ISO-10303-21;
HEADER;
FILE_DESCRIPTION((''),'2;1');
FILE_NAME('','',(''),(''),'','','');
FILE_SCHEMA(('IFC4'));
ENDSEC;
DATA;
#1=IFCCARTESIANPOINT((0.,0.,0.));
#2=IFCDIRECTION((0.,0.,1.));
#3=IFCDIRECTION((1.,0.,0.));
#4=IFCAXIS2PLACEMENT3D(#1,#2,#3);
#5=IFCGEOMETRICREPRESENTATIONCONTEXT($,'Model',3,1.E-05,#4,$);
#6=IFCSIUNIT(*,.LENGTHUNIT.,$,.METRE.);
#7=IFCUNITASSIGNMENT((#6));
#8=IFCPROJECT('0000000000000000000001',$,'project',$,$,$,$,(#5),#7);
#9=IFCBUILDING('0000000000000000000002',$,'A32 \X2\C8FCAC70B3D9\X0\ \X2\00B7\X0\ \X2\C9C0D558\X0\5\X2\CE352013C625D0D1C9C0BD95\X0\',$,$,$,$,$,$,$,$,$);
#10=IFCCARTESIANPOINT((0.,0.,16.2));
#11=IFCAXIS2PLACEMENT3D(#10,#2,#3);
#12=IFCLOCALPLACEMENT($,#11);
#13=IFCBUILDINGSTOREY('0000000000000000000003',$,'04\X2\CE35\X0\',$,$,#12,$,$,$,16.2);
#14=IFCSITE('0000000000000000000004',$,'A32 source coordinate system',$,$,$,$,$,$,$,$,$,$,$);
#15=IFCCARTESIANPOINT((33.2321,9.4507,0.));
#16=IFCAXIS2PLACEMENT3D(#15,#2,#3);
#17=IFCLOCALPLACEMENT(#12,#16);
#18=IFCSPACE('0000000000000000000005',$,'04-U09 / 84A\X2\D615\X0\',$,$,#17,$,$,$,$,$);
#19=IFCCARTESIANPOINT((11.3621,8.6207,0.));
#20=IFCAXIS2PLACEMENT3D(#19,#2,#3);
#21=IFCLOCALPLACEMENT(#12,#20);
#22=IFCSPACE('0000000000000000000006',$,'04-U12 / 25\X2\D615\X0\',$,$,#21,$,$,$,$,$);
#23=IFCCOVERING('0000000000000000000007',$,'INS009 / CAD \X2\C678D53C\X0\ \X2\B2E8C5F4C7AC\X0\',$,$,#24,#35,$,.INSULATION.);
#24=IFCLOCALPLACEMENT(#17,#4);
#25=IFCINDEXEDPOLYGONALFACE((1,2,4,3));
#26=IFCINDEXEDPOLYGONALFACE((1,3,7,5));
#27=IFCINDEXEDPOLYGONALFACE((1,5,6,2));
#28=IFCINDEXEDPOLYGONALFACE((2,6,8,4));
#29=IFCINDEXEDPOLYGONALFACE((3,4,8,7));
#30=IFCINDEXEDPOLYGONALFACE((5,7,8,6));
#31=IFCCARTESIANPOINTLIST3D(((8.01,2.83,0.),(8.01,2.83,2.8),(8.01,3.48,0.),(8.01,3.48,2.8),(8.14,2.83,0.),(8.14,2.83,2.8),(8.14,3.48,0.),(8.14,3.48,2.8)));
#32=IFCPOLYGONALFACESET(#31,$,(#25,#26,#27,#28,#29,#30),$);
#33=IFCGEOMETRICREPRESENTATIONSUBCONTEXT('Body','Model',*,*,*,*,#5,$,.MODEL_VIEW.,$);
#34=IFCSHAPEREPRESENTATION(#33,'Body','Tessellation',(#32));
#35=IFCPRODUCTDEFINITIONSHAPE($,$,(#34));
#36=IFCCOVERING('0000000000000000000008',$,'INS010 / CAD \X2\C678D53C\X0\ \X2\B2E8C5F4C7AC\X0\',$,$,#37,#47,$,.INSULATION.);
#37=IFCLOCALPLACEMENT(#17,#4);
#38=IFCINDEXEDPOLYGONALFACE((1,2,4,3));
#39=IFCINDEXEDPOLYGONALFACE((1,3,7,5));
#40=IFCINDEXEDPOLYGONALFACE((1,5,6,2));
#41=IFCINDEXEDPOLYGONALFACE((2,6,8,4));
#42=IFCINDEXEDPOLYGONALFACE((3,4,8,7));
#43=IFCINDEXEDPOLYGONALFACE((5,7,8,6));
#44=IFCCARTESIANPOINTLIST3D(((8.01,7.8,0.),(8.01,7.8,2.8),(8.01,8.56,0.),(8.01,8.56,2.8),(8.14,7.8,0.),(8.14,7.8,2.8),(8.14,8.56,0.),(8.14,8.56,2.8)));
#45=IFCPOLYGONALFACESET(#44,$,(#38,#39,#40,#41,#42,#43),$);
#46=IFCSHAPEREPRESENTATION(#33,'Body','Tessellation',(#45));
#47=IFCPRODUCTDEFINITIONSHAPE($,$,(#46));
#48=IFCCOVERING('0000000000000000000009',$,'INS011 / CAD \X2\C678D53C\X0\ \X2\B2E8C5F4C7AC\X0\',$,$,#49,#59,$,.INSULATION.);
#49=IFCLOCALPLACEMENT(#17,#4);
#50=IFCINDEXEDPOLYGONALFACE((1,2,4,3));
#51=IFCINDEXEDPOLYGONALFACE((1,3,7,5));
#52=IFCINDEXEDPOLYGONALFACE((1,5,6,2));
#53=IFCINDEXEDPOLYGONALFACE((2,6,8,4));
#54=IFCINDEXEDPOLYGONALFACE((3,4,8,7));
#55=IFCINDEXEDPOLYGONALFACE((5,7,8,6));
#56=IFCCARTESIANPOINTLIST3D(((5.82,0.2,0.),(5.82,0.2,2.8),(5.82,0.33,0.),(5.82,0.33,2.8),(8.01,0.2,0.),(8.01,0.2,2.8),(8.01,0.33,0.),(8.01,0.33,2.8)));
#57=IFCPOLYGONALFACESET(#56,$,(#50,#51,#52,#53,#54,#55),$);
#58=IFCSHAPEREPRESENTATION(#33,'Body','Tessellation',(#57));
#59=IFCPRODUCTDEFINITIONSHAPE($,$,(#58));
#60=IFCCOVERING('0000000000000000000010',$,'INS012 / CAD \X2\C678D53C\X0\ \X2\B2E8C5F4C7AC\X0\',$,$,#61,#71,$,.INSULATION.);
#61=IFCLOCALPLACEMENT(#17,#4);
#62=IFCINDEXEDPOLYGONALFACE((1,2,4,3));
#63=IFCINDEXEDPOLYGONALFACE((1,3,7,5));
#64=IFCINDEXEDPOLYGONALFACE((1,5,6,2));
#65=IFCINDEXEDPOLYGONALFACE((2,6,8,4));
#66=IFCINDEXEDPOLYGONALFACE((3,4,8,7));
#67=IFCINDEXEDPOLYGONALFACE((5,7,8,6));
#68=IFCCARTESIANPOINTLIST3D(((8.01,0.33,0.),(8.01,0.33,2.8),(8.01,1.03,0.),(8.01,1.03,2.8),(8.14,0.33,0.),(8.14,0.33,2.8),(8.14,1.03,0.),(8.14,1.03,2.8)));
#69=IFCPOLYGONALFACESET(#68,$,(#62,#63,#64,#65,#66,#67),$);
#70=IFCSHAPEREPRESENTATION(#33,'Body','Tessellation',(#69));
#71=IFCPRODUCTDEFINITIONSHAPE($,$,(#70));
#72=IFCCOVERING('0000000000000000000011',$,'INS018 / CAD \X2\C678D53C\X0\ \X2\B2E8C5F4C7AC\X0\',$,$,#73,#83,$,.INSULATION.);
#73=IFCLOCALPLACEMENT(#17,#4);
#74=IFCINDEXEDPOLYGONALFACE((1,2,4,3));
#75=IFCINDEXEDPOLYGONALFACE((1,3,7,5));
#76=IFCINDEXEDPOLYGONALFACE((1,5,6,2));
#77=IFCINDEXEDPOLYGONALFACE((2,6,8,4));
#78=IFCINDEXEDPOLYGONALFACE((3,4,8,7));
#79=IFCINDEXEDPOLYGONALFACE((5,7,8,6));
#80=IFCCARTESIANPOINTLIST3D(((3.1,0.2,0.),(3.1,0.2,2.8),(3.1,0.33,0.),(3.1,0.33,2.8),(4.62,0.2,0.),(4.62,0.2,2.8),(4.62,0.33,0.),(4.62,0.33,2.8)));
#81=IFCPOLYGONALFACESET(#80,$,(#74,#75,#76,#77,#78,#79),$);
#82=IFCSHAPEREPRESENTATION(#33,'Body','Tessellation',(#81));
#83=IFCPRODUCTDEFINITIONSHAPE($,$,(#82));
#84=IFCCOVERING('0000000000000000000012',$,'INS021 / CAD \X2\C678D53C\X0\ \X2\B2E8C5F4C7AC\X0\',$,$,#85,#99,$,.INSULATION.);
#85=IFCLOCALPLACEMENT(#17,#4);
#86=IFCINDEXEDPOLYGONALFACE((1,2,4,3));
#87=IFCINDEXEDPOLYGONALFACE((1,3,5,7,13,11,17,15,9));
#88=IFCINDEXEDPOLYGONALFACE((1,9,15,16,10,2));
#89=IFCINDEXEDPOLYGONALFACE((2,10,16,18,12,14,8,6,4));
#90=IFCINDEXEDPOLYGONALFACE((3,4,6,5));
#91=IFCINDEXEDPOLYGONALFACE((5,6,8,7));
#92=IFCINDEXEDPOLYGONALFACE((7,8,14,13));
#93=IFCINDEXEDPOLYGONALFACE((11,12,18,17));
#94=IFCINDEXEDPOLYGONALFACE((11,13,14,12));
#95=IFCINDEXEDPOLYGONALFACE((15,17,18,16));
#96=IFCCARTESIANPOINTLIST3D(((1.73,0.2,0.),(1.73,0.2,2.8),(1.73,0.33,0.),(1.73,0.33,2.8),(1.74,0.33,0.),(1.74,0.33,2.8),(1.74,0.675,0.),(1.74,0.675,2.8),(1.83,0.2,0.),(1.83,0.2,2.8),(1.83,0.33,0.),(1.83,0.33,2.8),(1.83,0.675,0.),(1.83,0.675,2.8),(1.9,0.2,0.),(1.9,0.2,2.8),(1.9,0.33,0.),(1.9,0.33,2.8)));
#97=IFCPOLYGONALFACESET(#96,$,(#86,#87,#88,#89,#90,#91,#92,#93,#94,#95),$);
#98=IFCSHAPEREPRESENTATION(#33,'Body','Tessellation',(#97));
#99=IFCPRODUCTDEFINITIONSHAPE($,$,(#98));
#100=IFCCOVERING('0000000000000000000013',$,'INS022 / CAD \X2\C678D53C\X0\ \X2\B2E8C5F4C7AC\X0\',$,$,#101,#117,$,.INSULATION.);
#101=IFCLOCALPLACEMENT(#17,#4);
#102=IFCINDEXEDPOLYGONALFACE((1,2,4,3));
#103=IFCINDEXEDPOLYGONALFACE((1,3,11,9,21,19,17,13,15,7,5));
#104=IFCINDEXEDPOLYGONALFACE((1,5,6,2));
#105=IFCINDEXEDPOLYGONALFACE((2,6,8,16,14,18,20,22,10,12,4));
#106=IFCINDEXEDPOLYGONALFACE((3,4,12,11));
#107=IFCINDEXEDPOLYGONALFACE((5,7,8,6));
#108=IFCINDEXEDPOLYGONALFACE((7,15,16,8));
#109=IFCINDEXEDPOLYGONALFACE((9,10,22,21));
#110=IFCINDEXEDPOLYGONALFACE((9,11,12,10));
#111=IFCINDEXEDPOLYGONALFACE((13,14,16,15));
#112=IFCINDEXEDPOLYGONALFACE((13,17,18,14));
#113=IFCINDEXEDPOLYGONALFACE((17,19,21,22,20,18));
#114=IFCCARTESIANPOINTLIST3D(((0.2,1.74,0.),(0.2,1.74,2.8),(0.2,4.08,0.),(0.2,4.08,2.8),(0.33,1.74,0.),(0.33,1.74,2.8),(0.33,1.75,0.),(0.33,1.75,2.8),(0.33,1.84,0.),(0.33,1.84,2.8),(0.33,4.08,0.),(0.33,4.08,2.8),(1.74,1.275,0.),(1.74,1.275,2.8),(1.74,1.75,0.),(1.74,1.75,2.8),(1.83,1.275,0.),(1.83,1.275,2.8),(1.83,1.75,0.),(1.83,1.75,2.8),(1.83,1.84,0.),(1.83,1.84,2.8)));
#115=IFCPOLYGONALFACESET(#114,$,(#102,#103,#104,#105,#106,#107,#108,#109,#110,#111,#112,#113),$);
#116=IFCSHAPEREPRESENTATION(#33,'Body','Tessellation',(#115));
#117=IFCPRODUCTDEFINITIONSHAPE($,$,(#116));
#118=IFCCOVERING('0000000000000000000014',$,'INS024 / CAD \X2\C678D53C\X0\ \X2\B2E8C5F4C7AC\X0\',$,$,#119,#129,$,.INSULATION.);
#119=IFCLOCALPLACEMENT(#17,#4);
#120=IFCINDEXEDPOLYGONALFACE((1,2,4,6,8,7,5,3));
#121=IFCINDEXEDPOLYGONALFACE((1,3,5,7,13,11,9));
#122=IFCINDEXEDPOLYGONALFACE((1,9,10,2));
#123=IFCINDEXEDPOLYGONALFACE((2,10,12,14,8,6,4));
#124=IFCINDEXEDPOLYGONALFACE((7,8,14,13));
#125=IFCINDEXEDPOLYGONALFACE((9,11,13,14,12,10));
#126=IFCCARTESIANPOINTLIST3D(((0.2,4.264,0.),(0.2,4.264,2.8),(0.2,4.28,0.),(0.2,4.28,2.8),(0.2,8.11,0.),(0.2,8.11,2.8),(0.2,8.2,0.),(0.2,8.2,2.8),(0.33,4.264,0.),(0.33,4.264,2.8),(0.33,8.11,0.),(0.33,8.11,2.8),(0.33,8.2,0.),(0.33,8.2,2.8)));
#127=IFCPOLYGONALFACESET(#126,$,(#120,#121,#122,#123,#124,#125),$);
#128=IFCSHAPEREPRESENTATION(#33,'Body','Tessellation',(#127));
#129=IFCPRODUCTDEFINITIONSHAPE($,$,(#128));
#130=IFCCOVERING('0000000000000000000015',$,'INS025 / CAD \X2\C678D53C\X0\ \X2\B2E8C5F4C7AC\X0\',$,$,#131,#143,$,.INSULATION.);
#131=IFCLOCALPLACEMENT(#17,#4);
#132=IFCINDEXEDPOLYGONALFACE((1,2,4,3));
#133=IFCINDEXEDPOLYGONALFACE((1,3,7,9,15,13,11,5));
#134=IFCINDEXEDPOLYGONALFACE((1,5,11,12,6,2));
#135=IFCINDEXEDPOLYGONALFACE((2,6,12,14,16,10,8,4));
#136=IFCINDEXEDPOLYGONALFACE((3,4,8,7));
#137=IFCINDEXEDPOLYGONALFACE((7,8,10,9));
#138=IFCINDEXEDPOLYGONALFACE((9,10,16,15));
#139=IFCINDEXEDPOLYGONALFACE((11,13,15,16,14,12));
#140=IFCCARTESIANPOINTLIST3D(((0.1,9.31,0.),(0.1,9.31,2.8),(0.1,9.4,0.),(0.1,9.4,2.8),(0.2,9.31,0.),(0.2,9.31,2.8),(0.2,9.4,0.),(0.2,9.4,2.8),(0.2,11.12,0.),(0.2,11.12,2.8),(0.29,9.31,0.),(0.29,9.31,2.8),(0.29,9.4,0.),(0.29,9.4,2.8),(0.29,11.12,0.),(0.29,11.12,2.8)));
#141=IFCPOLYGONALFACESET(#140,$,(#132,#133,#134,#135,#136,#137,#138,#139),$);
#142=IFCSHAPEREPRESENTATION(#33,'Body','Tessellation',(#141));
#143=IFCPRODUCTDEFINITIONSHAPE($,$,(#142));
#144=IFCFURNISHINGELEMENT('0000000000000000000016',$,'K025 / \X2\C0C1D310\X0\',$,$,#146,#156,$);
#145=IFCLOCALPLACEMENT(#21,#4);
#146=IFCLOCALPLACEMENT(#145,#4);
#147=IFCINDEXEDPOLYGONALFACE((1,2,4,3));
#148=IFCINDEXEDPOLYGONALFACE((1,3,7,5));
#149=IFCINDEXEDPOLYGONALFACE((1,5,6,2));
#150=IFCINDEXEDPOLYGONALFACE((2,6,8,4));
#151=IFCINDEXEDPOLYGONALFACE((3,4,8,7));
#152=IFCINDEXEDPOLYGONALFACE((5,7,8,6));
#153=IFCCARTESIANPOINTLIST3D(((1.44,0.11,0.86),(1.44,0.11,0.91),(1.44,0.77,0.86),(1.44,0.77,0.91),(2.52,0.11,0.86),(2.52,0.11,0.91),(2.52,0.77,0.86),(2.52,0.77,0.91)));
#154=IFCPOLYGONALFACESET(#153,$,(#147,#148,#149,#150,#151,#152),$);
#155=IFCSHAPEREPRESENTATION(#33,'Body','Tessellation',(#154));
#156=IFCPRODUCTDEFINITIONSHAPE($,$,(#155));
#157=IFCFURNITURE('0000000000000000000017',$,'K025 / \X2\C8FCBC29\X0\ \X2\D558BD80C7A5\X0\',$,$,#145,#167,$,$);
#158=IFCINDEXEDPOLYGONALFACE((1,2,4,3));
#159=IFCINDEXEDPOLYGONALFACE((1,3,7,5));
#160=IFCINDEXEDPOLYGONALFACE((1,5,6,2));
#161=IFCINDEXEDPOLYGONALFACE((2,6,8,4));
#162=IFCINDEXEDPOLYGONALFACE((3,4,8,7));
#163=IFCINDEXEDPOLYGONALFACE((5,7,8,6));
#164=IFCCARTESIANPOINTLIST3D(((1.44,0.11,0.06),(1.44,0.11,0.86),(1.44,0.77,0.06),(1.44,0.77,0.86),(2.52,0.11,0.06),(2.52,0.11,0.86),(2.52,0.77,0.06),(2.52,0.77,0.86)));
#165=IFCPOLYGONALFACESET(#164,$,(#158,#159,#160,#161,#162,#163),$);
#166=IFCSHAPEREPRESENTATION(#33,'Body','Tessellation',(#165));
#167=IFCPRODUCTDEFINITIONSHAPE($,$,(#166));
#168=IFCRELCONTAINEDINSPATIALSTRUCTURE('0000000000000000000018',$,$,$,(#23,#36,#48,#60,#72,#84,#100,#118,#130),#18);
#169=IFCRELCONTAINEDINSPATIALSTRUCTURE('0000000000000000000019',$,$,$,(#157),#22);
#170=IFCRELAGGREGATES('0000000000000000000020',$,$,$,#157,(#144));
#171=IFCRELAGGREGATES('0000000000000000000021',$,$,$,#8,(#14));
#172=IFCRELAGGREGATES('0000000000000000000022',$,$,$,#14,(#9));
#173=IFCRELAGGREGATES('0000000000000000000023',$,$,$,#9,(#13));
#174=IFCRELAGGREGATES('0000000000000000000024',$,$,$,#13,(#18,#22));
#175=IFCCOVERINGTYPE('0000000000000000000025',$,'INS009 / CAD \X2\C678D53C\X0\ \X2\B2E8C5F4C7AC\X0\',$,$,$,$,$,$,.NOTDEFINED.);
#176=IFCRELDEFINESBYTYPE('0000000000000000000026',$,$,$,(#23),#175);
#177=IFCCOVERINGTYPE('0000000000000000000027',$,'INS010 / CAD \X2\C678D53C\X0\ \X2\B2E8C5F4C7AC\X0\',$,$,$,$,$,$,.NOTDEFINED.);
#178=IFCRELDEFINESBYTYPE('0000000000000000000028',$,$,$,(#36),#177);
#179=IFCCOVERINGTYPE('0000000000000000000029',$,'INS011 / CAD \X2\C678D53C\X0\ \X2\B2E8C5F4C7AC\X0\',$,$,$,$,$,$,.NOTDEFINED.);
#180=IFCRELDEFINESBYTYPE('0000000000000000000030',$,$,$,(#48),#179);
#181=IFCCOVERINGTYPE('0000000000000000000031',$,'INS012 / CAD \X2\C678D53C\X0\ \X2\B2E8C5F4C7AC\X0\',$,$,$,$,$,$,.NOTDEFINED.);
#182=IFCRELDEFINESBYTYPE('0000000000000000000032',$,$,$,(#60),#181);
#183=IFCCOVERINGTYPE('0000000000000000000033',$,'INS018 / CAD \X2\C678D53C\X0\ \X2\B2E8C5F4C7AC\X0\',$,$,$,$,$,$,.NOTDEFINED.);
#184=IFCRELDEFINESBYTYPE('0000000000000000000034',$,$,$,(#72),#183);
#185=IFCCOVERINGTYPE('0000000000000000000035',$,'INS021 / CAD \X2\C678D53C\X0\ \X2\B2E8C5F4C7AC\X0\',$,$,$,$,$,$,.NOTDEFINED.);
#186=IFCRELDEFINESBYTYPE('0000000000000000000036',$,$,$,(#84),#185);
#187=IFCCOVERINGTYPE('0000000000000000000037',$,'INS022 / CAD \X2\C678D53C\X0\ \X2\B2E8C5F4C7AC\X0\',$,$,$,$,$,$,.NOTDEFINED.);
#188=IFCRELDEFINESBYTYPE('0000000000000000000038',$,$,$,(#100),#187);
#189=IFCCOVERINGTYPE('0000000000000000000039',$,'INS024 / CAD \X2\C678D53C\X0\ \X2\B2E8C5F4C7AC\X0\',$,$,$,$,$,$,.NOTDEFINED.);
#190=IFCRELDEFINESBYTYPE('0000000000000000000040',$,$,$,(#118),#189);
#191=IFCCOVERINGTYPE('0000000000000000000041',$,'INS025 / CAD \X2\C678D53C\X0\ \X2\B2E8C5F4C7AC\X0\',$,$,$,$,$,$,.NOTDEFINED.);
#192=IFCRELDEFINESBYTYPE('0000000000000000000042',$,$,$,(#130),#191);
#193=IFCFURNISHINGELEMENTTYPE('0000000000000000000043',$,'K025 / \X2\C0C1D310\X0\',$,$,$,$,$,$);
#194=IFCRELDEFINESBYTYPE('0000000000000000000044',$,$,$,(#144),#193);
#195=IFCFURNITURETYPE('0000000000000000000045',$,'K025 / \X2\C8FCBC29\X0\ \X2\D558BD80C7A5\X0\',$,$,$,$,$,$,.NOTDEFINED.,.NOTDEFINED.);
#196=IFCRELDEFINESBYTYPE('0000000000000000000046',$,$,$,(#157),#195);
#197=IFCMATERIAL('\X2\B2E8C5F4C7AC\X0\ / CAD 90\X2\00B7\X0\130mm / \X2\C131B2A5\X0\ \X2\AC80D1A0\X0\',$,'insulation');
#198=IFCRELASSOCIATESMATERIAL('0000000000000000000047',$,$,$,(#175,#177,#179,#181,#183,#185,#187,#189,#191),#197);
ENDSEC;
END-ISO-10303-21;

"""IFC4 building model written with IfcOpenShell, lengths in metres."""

from ifc_helpers import new_model, si_unit, frame, origin, origin_with_axes, place, context, subcontext, project, spatial, polyline, outline, extrude, source, transform, mapped, material, type_object, type_shapes, element, aggregate, save


model = new_model("IFC4")

# Units and contexts
model_context = context("Model", 3, precision=1e-05, world=origin_with_axes())
body_context = subcontext(model_context, "Body", "Model", "MODEL_VIEW")
ifc_project = project(units=[si_unit("LENGTHUNIT", "METRE")], contexts=[model_context])

# Site, building, storey, space
site = spatial("IfcSite", under=ifc_project, Name="A32 source coordinate system")
building = spatial("IfcBuilding", under=site, Name="A32 주거동 · 지하5층–옥탑지붕")
storey_placement = place(None, frame((0.0, 0.0, 16.2), z_axis=(0.0, 0.0, 1.0), x_axis=(1.0, 0.0, 0.0)))
storey = spatial("IfcBuildingStorey", under=building, at=storey_placement, Name="04층", Elevation=16.2)
space_1_placement = place(storey_placement, frame((33.2321, 9.4507, 0.0), z_axis=(0.0, 0.0, 1.0), x_axis=(1.0, 0.0, 0.0)))
space_1 = spatial("IfcSpace", under=storey, at=space_1_placement, Name="04-U09 / 84A형")

# Coverings
ifc_material = material(Name="단열재 / CAD 90·130mm / 성능 검토", Category="insulation")
covering_type_1 = type_object("IfcCoveringType", Name="INS009 / CAD 외피 단열재", PredefinedType="NOTDEFINED", material=ifc_material)
shared_shape_1 = source(origin(), body_context, "Body", "SweptSolid", [
    extrude(outline(polyline([(8.01, 2.83), (8.01, 3.48), (8.14, 3.48), (8.14, 2.83), (8.01, 2.83)])), origin(), (0.0, 0.0, 1.0), 2.8),
])
type_shapes(covering_type_1, [shared_shape_1])
covering_1_placement = place(space_1_placement, origin_with_axes())
element("IfcCovering", 1, at=covering_1_placement, inside=space_1, type_object=covering_type_1, Name="INS009 / CAD 외피 단열재", PredefinedType="INSULATION", context=body_context, shape_type="MappedRepresentation", body=[
    mapped(shared_shape_1, transform((0.0, 0.0, 0.0), scale=1.0)),
])
covering_type_2 = type_object("IfcCoveringType", Name="INS010 / CAD 외피 단열재", PredefinedType="NOTDEFINED", material=ifc_material)
shared_shape_2 = source(origin(), body_context, "Body", "SweptSolid", [
    extrude(outline(polyline([(8.14, 7.8), (8.01, 7.8), (8.01, 8.56), (8.14, 8.56), (8.14, 7.8)])), origin(), (0.0, 0.0, 1.0), 2.8),
])
type_shapes(covering_type_2, [shared_shape_2])
covering_2_placement = place(space_1_placement, origin_with_axes())
element("IfcCovering", 2, at=covering_2_placement, inside=space_1, type_object=covering_type_2, Name="INS010 / CAD 외피 단열재", PredefinedType="INSULATION", context=body_context, shape_type="MappedRepresentation", body=[
    mapped(shared_shape_2, transform((0.0, 0.0, 0.0), scale=1.0)),
])
covering_type_3 = type_object("IfcCoveringType", Name="INS011 / CAD 외피 단열재", PredefinedType="NOTDEFINED", material=ifc_material)
shared_shape_3 = source(origin(), body_context, "Body", "SweptSolid", [
    extrude(outline(polyline([(5.82, 0.33), (8.01, 0.33), (8.01, 0.2), (5.82, 0.2), (5.82, 0.33)])), origin(), (0.0, 0.0, 1.0), 2.8),
])
type_shapes(covering_type_3, [shared_shape_3])
covering_3_placement = place(space_1_placement, origin_with_axes())
element("IfcCovering", 3, at=covering_3_placement, inside=space_1, type_object=covering_type_3, Name="INS011 / CAD 외피 단열재", PredefinedType="INSULATION", context=body_context, shape_type="MappedRepresentation", body=[
    mapped(shared_shape_3, transform((0.0, 0.0, 0.0), scale=1.0)),
])
covering_type_4 = type_object("IfcCoveringType", Name="INS012 / CAD 외피 단열재", PredefinedType="NOTDEFINED", material=ifc_material)
shared_shape_4 = source(origin(), body_context, "Body", "SweptSolid", [
    extrude(outline(polyline([(8.01, 0.33), (8.01, 1.03), (8.14, 1.03), (8.14, 0.33), (8.01, 0.33)])), origin(), (0.0, 0.0, 1.0), 2.8),
])
type_shapes(covering_type_4, [shared_shape_4])
covering_4_placement = place(space_1_placement, origin_with_axes())
element("IfcCovering", 4, at=covering_4_placement, inside=space_1, type_object=covering_type_4, Name="INS012 / CAD 외피 단열재", PredefinedType="INSULATION", context=body_context, shape_type="MappedRepresentation", body=[
    mapped(shared_shape_4, transform((0.0, 0.0, 0.0), scale=1.0)),
])
covering_type_5 = type_object("IfcCoveringType", Name="INS018 / CAD 외피 단열재", PredefinedType="NOTDEFINED", material=ifc_material)
shared_shape_5 = source(origin(), body_context, "Body", "SweptSolid", [
    extrude(outline(polyline([(3.1, 0.33), (4.62, 0.33), (4.62, 0.2), (3.1, 0.2), (3.1, 0.33)])), origin(), (0.0, 0.0, 1.0), 2.8),
])
type_shapes(covering_type_5, [shared_shape_5])
covering_5_placement = place(space_1_placement, origin_with_axes())
element("IfcCovering", 5, at=covering_5_placement, inside=space_1, type_object=covering_type_5, Name="INS018 / CAD 외피 단열재", PredefinedType="INSULATION", context=body_context, shape_type="MappedRepresentation", body=[
    mapped(shared_shape_5, transform((0.0, 0.0, 0.0), scale=1.0)),
])
covering_type_6 = type_object("IfcCoveringType", Name="INS021 / CAD 외피 단열재", PredefinedType="NOTDEFINED", material=ifc_material)
shared_shape_6 = source(origin(), body_context, "Body", "SweptSolid", [
    extrude(outline(polyline([(1.83, 0.33), (1.9, 0.33), (1.9, 0.2), (1.83, 0.2), (1.73, 0.2), (1.73, 0.33), (1.74, 0.33), (1.74, 0.675), (1.83, 0.675), (1.83, 0.33)])), origin(), (0.0, 0.0, 1.0), 2.8),
])
type_shapes(covering_type_6, [shared_shape_6])
covering_6_placement = place(space_1_placement, origin_with_axes())
element("IfcCovering", 6, at=covering_6_placement, inside=space_1, type_object=covering_type_6, Name="INS021 / CAD 외피 단열재", PredefinedType="INSULATION", context=body_context, shape_type="MappedRepresentation", body=[
    mapped(shared_shape_6, transform((0.0, 0.0, 0.0), scale=1.0)),
])
covering_type_7 = type_object("IfcCoveringType", Name="INS022 / CAD 외피 단열재", PredefinedType="NOTDEFINED", material=ifc_material)
shared_shape_7 = source(origin(), body_context, "Body", "SweptSolid", [
    extrude(outline(polyline([(1.83, 1.84), (1.83, 1.75), (1.83, 1.275), (1.74, 1.275), (1.74, 1.75), (0.33, 1.75), (0.33, 1.74), (0.2, 1.74), (0.2, 4.08), (0.33, 4.08), (0.33, 1.84), (1.83, 1.84)])), origin(), (0.0, 0.0, 1.0), 2.8),
])
type_shapes(covering_type_7, [shared_shape_7])
covering_7_placement = place(space_1_placement, origin_with_axes())
element("IfcCovering", 7, at=covering_7_placement, inside=space_1, type_object=covering_type_7, Name="INS022 / CAD 외피 단열재", PredefinedType="INSULATION", context=body_context, shape_type="MappedRepresentation", body=[
    mapped(shared_shape_7, transform((0.0, 0.0, 0.0), scale=1.0)),
])
covering_type_8 = type_object("IfcCoveringType", Name="INS024 / CAD 외피 단열재", PredefinedType="NOTDEFINED", material=ifc_material)
shared_shape_8 = source(origin(), body_context, "Body", "SweptSolid", [
    extrude(outline(polyline([(0.2, 8.11), (0.2, 8.2), (0.33, 8.2), (0.33, 8.11), (0.33, 4.264), (0.2, 4.264), (0.2, 4.28), (0.2, 8.11)])), origin(), (0.0, 0.0, 1.0), 2.8),
])
type_shapes(covering_type_8, [shared_shape_8])
covering_8_placement = place(space_1_placement, origin_with_axes())
element("IfcCovering", 8, at=covering_8_placement, inside=space_1, type_object=covering_type_8, Name="INS024 / CAD 외피 단열재", PredefinedType="INSULATION", context=body_context, shape_type="MappedRepresentation", body=[
    mapped(shared_shape_8, transform((0.0, 0.0, 0.0), scale=1.0)),
])
covering_type_9 = type_object("IfcCoveringType", Name="INS025 / CAD 외피 단열재", PredefinedType="NOTDEFINED", material=ifc_material)
shared_shape_9 = source(origin(), body_context, "Body", "SweptSolid", [
    extrude(outline(polyline([(0.2, 9.4), (0.2, 11.12), (0.29, 11.12), (0.29, 9.4), (0.29, 9.31), (0.2, 9.31), (0.1, 9.31), (0.1, 9.4), (0.2, 9.4)])), origin(), (0.0, 0.0, 1.0), 2.8),
])
type_shapes(covering_type_9, [shared_shape_9])
covering_9_placement = place(space_1_placement, origin_with_axes())
element("IfcCovering", 9, at=covering_9_placement, inside=space_1, type_object=covering_type_9, Name="INS025 / CAD 외피 단열재", PredefinedType="INSULATION", context=body_context, shape_type="MappedRepresentation", body=[
    mapped(shared_shape_9, transform((0.0, 0.0, 0.0), scale=1.0)),
])

# Furnishing element
furnishing_element_type = type_object("IfcFurnishingElementType", Name="K025 / 상판")
shared_shape_10 = source(origin(), body_context, "Body", "SweptSolid", [
    extrude(outline(polyline([(2.52, 0.77), (2.52, 0.11), (1.44, 0.11), (1.44, 0.77), (2.52, 0.77)])), frame((0.0, 0.0, 0.86)), (0.0, 0.0, 1.0), 0.05),
])
type_shapes(furnishing_element_type, [shared_shape_10])
space_2_placement = place(storey_placement, frame((11.3621, 8.6207, 0.0), z_axis=(0.0, 0.0, 1.0), x_axis=(1.0, 0.0, 0.0)))
furniture_1_placement = place(space_2_placement, origin_with_axes())
furnishing_placement = place(furniture_1_placement, origin_with_axes())
furnishing = element("IfcFurnishingElement", 10, at=furnishing_placement, type_object=furnishing_element_type, Name="K025 / 상판", context=body_context, shape_type="MappedRepresentation", body=[
    mapped(shared_shape_10, transform((0.0, 0.0, 0.0), scale=1.0)),
])

# Shared definitions
space_2 = spatial("IfcSpace", under=storey, at=space_2_placement, Name="04-U12 / 25형")

# Furniture
furniture_type_1 = type_object("IfcFurnitureType", Name="K025 / 주방 하부장", AssemblyPlace="NOTDEFINED", PredefinedType="NOTDEFINED")
shared_shape_11 = source(origin(), body_context, "Body", "SweptSolid", [
    extrude(outline(polyline([(1.44, 0.77), (2.52, 0.77), (2.52, 0.11), (1.44, 0.11), (1.44, 0.77)])), frame((0.0, 0.0, 0.06)), (0.0, 0.0, 1.0), 0.8),
])
type_shapes(furniture_type_1, [shared_shape_11])
furniture_1 = element("IfcFurniture", 11, at=furniture_1_placement, inside=space_2, type_object=furniture_type_1, Name="K025 / 주방 하부장", context=body_context, shape_type="MappedRepresentation", body=[
    mapped(shared_shape_11, transform((0.0, 0.0, 0.0), scale=1.0)),
])
aggregate(furniture_1, [furnishing])

save(model, "model.ifc")
